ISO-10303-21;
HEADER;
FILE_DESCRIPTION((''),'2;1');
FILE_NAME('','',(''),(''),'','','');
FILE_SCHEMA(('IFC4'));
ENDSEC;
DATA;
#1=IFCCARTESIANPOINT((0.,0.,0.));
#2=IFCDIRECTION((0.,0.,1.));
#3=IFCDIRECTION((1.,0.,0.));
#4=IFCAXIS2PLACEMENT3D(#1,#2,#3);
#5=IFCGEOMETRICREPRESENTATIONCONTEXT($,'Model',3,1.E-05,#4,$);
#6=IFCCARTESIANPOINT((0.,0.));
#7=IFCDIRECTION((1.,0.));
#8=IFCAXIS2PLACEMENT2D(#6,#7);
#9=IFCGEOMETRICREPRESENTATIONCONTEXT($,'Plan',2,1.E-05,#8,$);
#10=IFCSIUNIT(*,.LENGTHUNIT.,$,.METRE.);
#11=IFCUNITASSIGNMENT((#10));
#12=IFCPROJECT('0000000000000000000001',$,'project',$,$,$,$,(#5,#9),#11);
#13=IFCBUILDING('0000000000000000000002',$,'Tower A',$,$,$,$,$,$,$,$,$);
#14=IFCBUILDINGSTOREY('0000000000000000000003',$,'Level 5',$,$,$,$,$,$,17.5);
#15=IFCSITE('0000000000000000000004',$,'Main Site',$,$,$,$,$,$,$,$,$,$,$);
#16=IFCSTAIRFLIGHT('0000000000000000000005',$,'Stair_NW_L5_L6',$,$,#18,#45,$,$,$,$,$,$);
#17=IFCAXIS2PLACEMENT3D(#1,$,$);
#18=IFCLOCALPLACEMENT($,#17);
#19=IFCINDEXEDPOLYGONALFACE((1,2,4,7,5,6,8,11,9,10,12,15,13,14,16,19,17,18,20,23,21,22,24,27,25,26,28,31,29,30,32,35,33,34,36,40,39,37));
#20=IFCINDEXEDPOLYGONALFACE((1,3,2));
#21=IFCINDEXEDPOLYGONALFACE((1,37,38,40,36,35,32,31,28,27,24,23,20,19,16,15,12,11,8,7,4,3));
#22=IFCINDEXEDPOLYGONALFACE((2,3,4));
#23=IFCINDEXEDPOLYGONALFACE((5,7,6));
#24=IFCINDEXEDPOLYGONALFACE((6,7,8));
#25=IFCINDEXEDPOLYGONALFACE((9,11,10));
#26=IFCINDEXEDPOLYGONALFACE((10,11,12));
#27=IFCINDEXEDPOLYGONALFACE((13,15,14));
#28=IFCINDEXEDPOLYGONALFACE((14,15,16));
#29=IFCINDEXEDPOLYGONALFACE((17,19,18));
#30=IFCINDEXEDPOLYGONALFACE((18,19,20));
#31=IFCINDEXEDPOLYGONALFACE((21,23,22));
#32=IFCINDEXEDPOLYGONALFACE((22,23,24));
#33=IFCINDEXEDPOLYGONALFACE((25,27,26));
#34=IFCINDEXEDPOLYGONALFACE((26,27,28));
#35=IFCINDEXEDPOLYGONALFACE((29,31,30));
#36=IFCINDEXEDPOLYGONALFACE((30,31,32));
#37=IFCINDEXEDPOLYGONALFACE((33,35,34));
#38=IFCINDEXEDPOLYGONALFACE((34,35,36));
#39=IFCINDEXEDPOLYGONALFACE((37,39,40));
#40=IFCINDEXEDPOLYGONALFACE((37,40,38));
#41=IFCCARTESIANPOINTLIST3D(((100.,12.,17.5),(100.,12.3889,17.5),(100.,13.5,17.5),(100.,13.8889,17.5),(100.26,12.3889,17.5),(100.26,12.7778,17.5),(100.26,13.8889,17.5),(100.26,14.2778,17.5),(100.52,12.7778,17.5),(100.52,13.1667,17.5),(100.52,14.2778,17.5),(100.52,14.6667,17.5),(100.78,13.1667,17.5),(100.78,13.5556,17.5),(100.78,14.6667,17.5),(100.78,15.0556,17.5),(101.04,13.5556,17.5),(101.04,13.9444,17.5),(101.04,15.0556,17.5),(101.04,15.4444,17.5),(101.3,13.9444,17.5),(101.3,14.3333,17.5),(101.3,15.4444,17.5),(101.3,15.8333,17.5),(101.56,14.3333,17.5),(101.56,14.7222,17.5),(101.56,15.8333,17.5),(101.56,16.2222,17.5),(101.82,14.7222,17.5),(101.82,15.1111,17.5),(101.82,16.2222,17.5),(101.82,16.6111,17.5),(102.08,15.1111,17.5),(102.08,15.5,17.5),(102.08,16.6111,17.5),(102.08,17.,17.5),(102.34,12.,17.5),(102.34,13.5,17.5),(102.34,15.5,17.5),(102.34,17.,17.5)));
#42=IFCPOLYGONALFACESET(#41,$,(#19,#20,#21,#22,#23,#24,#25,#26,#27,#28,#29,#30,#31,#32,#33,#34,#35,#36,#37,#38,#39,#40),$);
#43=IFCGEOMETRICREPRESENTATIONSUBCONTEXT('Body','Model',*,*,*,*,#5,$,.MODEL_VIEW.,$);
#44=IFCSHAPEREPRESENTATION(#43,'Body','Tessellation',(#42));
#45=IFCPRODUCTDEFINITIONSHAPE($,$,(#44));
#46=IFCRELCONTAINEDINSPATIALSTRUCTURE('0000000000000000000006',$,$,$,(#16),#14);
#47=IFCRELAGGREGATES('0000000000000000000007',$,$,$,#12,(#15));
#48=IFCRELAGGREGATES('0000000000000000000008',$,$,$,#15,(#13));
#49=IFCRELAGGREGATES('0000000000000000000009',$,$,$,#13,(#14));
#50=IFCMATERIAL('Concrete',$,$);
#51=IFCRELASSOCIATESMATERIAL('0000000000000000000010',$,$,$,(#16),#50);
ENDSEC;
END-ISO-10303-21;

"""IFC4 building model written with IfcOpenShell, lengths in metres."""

from ifc_helpers import new_model, si_unit, frame, origin_with_axes, origin_2d_with_axis, place, context, subcontext, project, spatial, line, indexed_curve, outline, extrude, material, element, save


model = new_model("IFC4")

# Units and contexts
model_context = context("Model", 3, precision=1e-05, world=origin_with_axes())
plan_context = context("Plan", 2, precision=1e-05, world=origin_2d_with_axis())
body_context = subcontext(model_context, "Body", "Model", "MODEL_VIEW")
ifc_project = project(units=[si_unit("LENGTHUNIT", "METRE")], contexts=[model_context, plan_context])

# Site, building, storey
site = spatial("IfcSite", under=ifc_project, Name="Main Site")
building = spatial("IfcBuilding", under=site, Name="Tower A")
storey = spatial("IfcBuildingStorey", under=building, Name="Level 5", Elevation=17.5)

# Stair flight
ifc_material_1 = material(Name="Concrete")
stair_flight_placement = place(None, frame((100.0, 12.0, 17.5), z_axis=(0.0, 0.0, 1.0), x_axis=(1.0, 0.0, 0.0)))
element("IfcStairFlight", 1, at=stair_flight_placement, inside=storey, material=ifc_material_1, Name="Stair_NW_L5_L6", context=body_context, shape_type="SweptSolid", body=[
    extrude(outline(indexed_curve([(0.0, 0.0), (0.0, 0.3889), (0.26, 0.3889), (0.26, 0.7778), (0.52, 0.7778), (0.52, 1.1667), (0.78, 1.1667), (0.78, 1.5556), (1.04, 1.5556), (1.04, 1.9444), (1.3, 1.9444), (1.3, 2.3333), (1.56, 2.3333), (1.56, 2.7222), (1.82, 2.7222), (1.82, 3.1111), (2.08, 3.1111), (2.08, 3.5), (2.34, 3.5), (2.34, 0.0)], segments=[line(1, 2, 3, 4, 5, 6, 7, 8, 9, 10, 11, 12, 13, 14, 15, 16, 17, 18, 19, 20, 1)])), origin_with_axes(), (0.0, 1.0, 0.0), 1.5),
])

save(model, "model.ifc")
